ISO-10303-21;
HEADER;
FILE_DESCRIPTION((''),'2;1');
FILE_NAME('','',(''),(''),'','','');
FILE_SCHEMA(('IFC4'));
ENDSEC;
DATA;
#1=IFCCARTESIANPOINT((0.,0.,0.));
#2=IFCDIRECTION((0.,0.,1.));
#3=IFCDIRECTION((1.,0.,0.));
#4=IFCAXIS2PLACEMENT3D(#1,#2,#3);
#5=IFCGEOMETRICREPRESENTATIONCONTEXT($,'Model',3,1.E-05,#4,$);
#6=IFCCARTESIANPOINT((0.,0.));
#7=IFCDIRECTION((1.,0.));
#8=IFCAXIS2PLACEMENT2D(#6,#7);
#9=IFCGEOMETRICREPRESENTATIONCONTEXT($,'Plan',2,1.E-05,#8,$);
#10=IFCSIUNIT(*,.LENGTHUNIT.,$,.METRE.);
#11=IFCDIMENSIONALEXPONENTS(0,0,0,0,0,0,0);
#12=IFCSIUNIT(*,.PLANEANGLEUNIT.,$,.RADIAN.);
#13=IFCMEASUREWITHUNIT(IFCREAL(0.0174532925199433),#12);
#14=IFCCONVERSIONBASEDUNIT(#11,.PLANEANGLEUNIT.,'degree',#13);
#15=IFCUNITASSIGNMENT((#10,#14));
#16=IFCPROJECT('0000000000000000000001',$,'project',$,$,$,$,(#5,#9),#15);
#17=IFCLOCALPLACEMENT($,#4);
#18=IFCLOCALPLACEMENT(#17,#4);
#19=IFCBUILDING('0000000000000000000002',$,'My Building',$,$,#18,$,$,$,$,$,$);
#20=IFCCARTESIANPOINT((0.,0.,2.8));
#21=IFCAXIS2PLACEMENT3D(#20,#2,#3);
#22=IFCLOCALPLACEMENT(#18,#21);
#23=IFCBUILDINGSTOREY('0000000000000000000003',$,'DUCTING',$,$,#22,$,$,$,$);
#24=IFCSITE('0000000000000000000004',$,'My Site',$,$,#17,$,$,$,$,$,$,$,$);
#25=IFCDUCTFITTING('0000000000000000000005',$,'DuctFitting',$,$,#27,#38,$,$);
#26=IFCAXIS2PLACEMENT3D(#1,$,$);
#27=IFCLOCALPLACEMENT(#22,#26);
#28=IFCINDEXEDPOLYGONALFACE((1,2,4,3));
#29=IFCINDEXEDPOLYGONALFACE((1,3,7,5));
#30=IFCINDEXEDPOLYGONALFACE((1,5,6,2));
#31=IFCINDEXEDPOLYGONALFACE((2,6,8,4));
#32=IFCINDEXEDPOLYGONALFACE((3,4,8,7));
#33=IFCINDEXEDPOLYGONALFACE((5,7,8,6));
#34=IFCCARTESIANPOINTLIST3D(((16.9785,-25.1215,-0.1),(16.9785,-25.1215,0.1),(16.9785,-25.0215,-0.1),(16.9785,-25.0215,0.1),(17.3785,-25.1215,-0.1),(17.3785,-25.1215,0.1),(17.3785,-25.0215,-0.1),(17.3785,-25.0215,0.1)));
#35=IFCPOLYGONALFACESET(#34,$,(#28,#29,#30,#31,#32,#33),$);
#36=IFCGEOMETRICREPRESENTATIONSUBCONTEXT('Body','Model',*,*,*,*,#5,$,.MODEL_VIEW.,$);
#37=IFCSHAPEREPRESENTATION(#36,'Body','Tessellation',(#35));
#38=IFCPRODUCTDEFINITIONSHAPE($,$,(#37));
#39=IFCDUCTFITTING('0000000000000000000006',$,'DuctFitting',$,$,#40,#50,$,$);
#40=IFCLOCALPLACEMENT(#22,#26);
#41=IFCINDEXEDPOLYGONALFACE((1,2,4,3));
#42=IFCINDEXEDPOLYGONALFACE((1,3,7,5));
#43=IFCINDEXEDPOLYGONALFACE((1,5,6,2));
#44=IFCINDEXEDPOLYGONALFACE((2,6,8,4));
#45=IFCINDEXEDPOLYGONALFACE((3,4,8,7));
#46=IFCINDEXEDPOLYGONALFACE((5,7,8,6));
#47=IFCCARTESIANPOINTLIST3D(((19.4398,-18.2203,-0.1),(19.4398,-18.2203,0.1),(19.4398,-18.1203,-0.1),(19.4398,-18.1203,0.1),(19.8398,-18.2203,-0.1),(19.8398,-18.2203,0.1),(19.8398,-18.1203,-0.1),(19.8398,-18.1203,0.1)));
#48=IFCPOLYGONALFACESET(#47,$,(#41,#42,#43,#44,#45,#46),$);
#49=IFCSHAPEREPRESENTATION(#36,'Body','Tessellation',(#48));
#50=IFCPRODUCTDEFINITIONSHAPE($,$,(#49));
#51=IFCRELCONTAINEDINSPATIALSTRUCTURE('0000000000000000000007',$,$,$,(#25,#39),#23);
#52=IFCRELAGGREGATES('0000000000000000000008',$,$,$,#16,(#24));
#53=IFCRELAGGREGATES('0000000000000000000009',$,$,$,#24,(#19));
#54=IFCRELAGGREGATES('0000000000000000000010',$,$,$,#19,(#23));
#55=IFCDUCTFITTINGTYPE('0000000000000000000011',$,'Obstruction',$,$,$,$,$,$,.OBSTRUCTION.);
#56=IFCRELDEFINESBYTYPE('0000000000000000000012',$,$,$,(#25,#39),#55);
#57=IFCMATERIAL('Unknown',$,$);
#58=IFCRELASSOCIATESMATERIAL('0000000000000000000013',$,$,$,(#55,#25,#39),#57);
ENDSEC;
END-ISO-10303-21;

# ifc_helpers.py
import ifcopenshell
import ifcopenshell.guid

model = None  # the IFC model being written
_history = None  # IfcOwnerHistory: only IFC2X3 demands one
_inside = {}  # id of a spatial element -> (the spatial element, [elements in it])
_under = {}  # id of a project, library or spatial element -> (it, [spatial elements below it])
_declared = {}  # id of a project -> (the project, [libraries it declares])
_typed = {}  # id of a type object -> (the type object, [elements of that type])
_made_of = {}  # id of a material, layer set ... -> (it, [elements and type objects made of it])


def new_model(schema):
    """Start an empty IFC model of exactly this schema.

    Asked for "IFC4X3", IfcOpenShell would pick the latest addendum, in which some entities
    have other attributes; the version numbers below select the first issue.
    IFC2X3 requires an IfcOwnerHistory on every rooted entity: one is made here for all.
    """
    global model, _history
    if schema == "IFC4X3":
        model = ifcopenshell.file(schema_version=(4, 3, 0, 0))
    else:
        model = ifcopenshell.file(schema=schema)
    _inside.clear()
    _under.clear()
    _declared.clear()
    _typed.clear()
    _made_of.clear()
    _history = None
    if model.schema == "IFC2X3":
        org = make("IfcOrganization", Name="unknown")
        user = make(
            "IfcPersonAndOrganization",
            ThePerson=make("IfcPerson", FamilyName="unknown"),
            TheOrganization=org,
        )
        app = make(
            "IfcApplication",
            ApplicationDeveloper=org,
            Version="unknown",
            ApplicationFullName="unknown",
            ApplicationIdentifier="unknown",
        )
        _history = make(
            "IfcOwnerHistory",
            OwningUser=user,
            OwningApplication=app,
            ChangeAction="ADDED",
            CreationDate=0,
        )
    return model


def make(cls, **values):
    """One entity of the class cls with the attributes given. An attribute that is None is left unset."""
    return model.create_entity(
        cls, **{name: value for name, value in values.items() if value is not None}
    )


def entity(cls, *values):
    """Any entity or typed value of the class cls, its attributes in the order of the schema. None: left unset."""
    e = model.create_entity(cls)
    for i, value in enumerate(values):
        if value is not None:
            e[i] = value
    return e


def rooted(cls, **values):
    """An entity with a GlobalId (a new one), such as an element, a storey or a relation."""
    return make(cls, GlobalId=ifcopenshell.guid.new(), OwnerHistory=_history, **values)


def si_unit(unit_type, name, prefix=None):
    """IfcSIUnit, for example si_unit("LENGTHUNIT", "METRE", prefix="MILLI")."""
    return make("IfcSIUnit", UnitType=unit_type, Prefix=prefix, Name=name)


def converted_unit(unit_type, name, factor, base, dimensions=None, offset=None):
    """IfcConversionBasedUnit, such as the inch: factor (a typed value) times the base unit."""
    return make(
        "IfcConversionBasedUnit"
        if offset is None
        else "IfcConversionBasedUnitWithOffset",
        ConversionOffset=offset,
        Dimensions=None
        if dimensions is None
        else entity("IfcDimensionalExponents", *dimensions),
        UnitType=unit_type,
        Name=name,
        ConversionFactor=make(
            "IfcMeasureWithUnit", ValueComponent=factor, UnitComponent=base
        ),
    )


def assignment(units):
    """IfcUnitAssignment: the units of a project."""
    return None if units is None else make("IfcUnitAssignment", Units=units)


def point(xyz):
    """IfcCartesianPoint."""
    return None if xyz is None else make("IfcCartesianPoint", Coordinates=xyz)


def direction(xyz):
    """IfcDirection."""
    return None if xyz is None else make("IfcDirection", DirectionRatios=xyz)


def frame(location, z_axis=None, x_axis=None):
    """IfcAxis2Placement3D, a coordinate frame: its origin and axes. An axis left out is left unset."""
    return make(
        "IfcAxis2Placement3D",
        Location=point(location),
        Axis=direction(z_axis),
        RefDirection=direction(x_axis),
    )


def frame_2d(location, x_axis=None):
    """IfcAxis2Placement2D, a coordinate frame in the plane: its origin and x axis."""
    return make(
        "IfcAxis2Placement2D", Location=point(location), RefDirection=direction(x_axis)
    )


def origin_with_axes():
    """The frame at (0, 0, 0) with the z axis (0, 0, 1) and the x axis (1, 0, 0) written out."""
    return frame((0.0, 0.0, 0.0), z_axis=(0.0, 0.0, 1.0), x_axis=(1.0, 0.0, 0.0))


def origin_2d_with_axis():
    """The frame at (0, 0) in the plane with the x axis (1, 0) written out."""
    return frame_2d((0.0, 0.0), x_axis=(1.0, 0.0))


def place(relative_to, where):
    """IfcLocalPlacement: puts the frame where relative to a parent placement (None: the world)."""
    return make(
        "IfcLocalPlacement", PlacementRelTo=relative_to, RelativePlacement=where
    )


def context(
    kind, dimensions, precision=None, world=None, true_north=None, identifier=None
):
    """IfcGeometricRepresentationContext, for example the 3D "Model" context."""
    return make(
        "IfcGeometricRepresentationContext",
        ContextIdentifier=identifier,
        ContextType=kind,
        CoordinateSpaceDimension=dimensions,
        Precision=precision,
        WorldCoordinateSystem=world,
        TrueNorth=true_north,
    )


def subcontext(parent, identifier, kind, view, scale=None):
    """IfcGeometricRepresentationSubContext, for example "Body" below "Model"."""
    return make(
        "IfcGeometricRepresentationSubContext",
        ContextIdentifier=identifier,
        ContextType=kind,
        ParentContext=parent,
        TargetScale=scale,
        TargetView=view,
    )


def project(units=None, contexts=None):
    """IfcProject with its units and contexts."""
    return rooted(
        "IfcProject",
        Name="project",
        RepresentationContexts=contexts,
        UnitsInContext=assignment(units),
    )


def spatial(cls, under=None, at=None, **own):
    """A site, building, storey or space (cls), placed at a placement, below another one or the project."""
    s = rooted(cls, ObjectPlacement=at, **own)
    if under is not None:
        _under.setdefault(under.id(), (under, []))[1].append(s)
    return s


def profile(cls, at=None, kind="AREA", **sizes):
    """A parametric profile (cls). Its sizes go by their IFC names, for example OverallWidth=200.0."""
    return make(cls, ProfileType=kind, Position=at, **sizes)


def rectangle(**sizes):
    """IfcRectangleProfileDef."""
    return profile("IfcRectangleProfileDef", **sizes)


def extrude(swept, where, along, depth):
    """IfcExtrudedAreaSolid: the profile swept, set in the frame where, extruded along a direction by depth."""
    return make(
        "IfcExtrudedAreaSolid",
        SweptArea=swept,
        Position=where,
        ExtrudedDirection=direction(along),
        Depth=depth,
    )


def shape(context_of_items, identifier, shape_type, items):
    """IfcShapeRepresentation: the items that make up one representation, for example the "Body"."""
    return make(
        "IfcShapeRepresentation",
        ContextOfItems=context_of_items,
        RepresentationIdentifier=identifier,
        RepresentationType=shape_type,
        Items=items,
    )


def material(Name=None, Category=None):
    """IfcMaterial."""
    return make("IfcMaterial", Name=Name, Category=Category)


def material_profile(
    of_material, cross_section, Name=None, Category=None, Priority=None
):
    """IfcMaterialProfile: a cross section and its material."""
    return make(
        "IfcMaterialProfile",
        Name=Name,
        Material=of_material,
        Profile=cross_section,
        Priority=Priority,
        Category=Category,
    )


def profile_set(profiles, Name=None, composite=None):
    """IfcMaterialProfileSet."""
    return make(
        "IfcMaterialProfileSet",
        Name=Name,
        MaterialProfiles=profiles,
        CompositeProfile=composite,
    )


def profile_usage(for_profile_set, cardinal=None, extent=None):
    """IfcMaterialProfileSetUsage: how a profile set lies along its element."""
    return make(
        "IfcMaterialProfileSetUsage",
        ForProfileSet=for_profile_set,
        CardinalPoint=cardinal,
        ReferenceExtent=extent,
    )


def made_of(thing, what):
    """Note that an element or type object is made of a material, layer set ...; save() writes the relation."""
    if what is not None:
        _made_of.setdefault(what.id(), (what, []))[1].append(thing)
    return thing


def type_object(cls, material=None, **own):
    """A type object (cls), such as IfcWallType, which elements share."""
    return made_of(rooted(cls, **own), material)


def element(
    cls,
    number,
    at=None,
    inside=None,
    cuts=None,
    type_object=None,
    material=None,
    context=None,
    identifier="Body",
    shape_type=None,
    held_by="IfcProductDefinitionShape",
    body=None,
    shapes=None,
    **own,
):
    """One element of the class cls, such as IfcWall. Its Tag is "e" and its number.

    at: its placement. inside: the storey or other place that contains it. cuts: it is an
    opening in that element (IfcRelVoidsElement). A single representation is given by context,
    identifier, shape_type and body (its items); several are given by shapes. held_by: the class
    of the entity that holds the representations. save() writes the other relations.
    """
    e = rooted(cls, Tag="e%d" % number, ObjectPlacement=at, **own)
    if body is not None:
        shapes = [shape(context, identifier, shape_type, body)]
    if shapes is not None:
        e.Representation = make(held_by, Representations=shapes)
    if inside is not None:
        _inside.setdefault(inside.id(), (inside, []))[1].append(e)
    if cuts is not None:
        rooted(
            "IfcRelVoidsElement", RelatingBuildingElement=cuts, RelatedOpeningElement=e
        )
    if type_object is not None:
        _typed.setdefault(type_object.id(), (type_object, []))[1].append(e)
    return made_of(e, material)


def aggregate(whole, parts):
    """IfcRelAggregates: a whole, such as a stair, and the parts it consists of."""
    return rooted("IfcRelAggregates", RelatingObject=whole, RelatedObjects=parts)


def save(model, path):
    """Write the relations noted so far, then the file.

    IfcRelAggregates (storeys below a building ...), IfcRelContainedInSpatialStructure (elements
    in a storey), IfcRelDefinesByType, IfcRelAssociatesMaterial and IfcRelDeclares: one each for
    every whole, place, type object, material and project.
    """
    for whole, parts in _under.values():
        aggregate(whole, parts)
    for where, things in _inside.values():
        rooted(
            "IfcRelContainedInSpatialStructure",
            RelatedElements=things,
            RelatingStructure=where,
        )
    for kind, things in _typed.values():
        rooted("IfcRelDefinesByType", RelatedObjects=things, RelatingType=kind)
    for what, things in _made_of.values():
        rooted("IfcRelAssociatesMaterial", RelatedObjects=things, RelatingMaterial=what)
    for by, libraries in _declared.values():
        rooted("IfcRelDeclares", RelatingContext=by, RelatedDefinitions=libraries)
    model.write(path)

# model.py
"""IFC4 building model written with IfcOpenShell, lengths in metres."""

from ifc_helpers import new_model, entity, si_unit, converted_unit, frame, origin_with_axes, origin_2d_with_axis, place, context, subcontext, project, spatial, rectangle, extrude, material, material_profile, profile_set, profile_usage, type_object, element, save


model = new_model("IFC4")

# Units and contexts
model_context = context("Model", 3, precision=1e-05, world=origin_with_axes())
plan_context = context("Plan", 2, precision=1e-05, world=origin_2d_with_axis())
body_context = subcontext(model_context, "Body", "Model", "MODEL_VIEW")
ifc_project = project(units=[si_unit("LENGTHUNIT", "METRE"), converted_unit("PLANEANGLEUNIT", "degree", entity("IfcReal", 0.0174532925199433), si_unit("PLANEANGLEUNIT", "RADIAN"), dimensions=[0, 0, 0, 0, 0, 0, 0])], contexts=[model_context, plan_context])

# Site, building, storey
site_placement = place(None, origin_with_axes())
site = spatial("IfcSite", under=ifc_project, at=site_placement, Name="My Site")
building_placement = place(site_placement, origin_with_axes())
building = spatial("IfcBuilding", under=site, at=building_placement, Name="My Building")
storey_placement = place(building_placement, frame((0.0, 0.0, 2.8), z_axis=(0.0, 0.0, 1.0), x_axis=(1.0, 0.0, 0.0)))
storey = spatial("IfcBuildingStorey", under=building, at=storey_placement, Name="DUCTING")

# Shared definitions
ifc_material = material(Name="Unknown")

# Duct fittings
ifc_material_profile_1 = material_profile(ifc_material, rectangle(XDim=0.4, YDim=0.2))
ifc_profile_set_1 = profile_set([ifc_material_profile_1])
duct_fitting_type_1 = type_object("IfcDuctFittingType", Name="Obstruction", PredefinedType="OBSTRUCTION", material=ifc_profile_set_1)
ifc_profile_usage_1 = profile_usage(ifc_profile_set_1, cardinal=5)
duct_fitting_1_placement = place(storey_placement, frame((17.1785, -25.1215, 0.0), z_axis=(0.0, 1.0, 0.0), x_axis=(-1.0, 0.0, 0.0)))
element("IfcDuctFitting", 1, at=duct_fitting_1_placement, inside=storey, type_object=duct_fitting_type_1, material=ifc_profile_usage_1, Name="DuctFitting", context=body_context, shape_type="SweptSolid", body=[
    extrude(rectangle(XDim=0.4, YDim=0.2), origin_with_axes(), (0.0, 0.0, 1.0), 0.1),
])
ifc_profile_usage_2 = profile_usage(ifc_profile_set_1, cardinal=5)
duct_fitting_2_placement = place(storey_placement, frame((19.6398, -18.2203, 0.0), z_axis=(0.0, 1.0, 0.0), x_axis=(-1.0, 0.0, 0.0)))
element("IfcDuctFitting", 2, at=duct_fitting_2_placement, inside=storey, type_object=duct_fitting_type_1, material=ifc_profile_usage_2, Name="DuctFitting", context=body_context, shape_type="SweptSolid", body=[
    extrude(rectangle(XDim=0.4, YDim=0.2), origin_with_axes(), (0.0, 0.0, 1.0), 0.1),
])

save(model, "model.ifc")
